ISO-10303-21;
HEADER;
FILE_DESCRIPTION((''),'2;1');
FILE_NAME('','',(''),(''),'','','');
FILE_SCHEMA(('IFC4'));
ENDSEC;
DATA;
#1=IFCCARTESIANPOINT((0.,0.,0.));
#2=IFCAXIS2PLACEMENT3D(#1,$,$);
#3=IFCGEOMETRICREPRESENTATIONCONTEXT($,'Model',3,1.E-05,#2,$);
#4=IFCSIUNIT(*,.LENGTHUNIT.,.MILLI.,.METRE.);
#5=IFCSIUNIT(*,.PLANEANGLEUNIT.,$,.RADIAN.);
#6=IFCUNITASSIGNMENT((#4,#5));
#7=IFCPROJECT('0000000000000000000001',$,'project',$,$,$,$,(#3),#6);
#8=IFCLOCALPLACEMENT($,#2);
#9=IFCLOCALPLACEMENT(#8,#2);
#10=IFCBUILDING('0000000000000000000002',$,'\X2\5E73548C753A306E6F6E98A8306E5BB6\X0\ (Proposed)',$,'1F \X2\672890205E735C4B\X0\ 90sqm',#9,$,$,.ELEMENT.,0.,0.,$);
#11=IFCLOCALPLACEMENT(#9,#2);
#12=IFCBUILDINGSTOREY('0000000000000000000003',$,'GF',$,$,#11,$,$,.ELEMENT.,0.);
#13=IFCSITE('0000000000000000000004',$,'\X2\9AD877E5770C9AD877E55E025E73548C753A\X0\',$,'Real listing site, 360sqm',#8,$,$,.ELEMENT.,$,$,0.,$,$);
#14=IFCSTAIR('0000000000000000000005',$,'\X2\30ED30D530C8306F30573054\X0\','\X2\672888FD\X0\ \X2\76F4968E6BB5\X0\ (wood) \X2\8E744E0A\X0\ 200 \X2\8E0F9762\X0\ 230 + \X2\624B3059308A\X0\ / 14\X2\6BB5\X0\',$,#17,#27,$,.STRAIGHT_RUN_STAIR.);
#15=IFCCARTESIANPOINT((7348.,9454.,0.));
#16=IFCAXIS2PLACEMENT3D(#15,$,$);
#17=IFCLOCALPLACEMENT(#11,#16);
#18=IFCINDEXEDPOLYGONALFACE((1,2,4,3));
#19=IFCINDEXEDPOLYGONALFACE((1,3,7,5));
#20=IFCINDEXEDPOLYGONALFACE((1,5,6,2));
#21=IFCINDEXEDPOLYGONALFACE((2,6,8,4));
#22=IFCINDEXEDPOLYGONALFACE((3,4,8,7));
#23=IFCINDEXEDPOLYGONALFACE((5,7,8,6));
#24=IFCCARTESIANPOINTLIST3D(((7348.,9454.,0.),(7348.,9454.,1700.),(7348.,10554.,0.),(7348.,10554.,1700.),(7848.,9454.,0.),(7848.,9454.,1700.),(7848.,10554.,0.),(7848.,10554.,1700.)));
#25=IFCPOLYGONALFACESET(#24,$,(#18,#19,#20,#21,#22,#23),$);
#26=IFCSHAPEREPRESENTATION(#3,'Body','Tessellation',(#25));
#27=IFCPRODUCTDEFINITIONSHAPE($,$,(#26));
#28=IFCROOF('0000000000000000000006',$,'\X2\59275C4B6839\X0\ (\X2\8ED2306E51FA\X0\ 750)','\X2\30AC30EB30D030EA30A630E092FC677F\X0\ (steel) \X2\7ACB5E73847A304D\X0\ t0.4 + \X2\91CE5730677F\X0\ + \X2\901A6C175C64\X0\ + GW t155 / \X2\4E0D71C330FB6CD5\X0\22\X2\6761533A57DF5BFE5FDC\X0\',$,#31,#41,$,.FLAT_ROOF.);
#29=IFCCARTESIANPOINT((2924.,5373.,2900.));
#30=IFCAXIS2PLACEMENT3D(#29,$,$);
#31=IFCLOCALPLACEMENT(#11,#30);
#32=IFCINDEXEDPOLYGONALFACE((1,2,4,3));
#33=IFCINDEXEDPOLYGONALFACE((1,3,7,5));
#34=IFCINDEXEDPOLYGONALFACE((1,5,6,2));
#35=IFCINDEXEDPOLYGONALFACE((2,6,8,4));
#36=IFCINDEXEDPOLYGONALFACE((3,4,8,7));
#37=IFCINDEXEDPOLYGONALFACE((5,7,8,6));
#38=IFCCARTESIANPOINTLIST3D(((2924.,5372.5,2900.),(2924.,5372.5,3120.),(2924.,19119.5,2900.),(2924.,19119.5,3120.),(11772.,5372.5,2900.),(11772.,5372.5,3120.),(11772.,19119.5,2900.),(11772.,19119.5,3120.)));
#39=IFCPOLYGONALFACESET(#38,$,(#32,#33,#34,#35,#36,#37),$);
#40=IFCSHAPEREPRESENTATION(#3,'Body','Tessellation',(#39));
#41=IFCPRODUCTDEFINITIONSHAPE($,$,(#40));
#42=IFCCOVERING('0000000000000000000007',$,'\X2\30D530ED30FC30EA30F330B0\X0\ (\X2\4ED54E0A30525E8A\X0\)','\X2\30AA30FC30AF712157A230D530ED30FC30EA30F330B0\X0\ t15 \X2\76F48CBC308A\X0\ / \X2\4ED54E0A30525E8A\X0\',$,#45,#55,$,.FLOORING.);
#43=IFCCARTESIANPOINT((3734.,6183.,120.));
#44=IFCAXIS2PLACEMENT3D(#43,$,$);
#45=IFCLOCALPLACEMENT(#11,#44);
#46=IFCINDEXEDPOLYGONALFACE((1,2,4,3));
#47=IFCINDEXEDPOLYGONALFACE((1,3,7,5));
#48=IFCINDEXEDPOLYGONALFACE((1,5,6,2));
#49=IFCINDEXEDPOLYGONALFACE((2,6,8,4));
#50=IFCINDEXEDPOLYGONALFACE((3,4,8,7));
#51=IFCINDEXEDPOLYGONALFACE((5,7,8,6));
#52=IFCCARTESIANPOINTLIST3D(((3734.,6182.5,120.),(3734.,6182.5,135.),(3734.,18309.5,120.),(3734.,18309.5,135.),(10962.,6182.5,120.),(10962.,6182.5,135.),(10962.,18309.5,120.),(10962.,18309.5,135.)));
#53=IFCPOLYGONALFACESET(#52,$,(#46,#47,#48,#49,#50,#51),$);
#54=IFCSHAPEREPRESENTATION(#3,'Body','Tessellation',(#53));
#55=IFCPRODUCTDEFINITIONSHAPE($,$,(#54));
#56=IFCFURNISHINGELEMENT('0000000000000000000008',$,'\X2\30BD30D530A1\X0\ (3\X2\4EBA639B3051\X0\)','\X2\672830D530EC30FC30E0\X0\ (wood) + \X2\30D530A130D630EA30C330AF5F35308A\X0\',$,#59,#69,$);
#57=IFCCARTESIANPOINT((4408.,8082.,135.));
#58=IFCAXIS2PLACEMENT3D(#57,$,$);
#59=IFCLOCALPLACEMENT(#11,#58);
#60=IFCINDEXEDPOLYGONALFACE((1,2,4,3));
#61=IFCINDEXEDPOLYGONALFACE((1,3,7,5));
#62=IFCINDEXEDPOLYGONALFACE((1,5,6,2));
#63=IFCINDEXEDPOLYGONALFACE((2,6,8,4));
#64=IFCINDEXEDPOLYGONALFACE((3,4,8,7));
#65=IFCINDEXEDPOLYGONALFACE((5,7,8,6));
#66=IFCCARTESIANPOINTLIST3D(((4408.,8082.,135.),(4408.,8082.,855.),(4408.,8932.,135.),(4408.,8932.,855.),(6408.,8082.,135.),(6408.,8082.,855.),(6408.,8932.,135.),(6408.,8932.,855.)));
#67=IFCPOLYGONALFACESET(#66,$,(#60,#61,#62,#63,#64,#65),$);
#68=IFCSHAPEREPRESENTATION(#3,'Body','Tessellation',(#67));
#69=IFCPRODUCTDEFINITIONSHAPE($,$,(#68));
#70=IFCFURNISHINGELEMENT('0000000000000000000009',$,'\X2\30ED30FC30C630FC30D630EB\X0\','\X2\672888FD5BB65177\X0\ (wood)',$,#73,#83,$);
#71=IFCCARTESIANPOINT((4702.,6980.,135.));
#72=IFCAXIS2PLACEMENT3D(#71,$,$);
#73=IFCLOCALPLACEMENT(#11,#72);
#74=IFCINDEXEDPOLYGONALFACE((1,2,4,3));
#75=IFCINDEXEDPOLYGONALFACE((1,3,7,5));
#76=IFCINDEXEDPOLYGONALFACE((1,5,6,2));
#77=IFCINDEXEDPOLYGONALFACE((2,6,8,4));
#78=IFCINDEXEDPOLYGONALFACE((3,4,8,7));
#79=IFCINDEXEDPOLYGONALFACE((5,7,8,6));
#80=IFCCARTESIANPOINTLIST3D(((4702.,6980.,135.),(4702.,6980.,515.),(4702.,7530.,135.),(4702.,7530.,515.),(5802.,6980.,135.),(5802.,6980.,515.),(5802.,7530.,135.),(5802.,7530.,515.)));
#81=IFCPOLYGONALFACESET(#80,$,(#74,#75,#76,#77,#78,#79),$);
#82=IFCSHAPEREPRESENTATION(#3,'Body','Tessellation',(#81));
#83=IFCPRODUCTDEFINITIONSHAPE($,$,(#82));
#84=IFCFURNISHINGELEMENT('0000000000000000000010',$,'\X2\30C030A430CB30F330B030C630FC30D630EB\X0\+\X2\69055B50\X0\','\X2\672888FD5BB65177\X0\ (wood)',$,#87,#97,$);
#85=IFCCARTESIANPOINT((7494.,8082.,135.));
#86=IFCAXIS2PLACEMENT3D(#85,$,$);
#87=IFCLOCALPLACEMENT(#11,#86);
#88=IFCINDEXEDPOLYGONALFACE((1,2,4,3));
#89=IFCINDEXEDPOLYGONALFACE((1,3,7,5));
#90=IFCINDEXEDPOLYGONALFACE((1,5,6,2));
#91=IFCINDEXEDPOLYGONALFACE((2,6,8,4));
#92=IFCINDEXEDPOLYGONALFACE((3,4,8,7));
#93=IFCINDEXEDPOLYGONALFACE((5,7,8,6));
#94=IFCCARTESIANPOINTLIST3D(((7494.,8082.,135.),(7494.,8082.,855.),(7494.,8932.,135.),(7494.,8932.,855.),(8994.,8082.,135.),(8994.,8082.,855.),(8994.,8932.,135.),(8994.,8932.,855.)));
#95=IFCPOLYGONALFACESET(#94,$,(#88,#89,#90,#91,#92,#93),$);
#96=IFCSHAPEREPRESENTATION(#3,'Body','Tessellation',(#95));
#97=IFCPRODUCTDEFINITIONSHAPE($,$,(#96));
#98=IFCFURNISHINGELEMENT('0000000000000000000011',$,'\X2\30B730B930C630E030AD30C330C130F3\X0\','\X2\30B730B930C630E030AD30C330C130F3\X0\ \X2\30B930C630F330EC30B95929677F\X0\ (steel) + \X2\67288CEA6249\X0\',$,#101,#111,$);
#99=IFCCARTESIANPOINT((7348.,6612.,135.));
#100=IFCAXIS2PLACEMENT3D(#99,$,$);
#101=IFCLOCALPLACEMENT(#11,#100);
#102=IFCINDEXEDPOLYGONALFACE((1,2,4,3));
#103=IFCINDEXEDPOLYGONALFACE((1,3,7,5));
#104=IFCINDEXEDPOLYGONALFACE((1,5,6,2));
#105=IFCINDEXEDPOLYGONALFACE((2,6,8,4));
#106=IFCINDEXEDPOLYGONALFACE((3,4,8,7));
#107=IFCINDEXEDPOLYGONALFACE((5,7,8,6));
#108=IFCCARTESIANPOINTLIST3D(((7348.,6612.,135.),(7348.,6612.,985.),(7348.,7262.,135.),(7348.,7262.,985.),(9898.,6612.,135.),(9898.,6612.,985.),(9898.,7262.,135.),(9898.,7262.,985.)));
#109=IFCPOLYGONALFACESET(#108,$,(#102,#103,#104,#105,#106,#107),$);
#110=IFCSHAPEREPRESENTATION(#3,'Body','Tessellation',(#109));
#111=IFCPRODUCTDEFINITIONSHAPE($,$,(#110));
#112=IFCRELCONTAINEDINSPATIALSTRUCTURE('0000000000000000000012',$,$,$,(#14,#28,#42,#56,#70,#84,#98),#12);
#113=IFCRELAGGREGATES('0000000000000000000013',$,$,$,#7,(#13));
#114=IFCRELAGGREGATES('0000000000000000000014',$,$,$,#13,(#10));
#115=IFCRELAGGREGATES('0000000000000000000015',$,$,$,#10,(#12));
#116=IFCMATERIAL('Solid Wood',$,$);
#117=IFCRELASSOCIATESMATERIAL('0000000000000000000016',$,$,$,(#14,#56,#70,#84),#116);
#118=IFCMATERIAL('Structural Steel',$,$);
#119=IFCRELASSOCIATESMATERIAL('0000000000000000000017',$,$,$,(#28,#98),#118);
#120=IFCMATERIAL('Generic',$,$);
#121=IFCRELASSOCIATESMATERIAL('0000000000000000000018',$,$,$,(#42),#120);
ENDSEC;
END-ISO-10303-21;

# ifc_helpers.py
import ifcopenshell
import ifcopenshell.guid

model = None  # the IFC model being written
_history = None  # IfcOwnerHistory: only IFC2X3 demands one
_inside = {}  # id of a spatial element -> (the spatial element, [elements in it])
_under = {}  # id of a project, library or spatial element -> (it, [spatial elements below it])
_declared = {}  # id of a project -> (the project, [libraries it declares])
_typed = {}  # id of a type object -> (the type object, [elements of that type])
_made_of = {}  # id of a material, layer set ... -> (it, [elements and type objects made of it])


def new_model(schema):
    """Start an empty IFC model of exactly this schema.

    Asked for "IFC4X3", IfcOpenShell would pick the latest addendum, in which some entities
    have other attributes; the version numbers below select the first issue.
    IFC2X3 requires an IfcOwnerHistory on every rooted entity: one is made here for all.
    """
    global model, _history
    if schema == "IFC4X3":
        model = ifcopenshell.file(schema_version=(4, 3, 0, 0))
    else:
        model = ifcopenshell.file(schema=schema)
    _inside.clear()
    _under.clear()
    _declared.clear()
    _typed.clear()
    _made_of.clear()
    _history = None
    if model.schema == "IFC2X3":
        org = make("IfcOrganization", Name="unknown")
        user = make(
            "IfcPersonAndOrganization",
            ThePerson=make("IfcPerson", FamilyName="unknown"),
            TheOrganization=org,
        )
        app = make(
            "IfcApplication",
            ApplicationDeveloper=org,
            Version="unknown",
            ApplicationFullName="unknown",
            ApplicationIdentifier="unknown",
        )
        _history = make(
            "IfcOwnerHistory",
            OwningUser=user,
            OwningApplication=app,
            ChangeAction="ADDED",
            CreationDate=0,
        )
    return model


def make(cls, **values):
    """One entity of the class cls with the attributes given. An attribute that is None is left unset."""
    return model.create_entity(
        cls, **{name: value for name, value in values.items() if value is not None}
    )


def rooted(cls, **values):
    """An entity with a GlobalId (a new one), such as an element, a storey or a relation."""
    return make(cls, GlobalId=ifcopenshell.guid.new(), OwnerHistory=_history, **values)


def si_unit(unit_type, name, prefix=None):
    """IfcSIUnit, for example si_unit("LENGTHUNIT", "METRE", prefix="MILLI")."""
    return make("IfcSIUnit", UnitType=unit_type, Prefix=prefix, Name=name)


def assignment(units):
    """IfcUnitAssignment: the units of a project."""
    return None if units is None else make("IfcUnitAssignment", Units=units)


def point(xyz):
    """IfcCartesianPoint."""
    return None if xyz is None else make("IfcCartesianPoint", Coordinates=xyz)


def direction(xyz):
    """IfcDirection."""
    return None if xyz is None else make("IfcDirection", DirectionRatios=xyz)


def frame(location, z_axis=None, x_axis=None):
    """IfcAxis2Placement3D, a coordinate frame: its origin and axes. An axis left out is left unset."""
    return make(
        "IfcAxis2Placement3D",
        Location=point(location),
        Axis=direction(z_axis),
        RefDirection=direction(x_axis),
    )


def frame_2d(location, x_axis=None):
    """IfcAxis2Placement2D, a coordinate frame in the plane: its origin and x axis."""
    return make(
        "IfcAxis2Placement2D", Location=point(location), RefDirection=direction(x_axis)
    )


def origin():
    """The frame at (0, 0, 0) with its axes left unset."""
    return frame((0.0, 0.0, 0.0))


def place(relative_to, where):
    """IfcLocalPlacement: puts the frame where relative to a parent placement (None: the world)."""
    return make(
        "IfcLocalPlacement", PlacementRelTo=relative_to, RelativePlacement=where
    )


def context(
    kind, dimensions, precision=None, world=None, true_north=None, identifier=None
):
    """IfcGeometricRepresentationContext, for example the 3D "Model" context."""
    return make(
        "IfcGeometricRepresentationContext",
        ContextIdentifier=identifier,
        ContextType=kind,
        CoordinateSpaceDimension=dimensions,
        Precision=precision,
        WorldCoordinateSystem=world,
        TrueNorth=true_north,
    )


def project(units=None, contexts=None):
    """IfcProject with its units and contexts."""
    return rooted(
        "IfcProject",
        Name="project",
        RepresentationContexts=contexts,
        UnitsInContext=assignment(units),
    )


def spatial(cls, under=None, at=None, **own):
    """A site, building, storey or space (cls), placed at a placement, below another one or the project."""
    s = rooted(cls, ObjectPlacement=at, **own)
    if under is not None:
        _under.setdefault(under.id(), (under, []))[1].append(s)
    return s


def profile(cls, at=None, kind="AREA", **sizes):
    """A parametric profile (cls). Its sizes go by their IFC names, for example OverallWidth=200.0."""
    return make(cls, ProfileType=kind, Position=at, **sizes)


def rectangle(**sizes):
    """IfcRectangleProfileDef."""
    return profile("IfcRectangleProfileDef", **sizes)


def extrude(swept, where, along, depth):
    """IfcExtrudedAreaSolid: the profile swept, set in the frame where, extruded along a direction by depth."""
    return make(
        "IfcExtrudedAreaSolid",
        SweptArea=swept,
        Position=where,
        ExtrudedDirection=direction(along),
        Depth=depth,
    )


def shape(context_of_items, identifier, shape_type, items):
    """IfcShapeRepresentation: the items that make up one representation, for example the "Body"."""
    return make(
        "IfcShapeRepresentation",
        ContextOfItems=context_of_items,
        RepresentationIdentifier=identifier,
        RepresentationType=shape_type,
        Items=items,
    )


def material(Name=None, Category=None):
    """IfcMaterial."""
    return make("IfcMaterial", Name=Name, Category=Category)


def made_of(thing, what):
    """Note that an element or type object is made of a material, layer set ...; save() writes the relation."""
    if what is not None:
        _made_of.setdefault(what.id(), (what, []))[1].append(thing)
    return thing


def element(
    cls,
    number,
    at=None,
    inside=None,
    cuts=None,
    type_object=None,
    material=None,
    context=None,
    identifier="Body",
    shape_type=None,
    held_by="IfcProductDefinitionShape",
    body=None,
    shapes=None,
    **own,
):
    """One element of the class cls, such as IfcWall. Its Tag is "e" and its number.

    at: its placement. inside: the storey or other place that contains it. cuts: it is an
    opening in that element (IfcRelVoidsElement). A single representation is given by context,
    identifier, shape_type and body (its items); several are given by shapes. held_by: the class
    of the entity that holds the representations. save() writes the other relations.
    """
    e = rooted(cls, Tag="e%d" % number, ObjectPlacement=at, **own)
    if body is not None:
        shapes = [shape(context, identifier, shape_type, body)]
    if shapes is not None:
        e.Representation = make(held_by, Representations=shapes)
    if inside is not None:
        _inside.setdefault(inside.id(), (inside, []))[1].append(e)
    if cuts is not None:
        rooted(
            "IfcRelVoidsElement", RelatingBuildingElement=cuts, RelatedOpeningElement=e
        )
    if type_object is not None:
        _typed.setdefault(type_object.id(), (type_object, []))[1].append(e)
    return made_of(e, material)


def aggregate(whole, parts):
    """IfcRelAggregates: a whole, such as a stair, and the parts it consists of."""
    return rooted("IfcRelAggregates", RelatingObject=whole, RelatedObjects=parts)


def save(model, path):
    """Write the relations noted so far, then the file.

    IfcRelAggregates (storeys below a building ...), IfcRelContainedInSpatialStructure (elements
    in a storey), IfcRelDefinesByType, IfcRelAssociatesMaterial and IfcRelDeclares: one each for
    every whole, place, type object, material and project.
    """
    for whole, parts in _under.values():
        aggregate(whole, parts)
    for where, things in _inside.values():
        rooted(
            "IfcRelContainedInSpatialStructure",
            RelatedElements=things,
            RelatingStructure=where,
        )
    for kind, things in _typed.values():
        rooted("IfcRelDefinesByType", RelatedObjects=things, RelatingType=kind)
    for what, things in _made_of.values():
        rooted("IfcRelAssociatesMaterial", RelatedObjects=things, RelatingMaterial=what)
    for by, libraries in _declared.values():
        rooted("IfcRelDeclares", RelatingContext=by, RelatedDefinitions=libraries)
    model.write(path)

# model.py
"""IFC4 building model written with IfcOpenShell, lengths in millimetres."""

from ifc_helpers import new_model, si_unit, frame, frame_2d, origin, place, context, project, spatial, rectangle, extrude, material, element, save


model = new_model("IFC4")

# Units and contexts
model_context = context("Model", 3, precision=1e-05, world=origin())
ifc_project = project(units=[si_unit("LENGTHUNIT", "METRE", prefix="MILLI"), si_unit("PLANEANGLEUNIT", "RADIAN")], contexts=[model_context])

# Site, building, storey
site_placement = place(None, origin())
site = spatial("IfcSite", under=ifc_project, at=site_placement, Name="高知県高知市平和町", ObjectType="Real listing site, 360sqm", CompositionType="ELEMENT", RefElevation=0.0)
building_placement = place(site_placement, origin())
building = spatial("IfcBuilding", under=site, at=building_placement, Name="平和町の潮風の家 (Proposed)", ObjectType="1F 木造平屋 90sqm", CompositionType="ELEMENT", ElevationOfRefHeight=0.0, ElevationOfTerrain=0.0)
storey_placement = place(building_placement, origin())
storey = spatial("IfcBuildingStorey", under=building, at=storey_placement, Name="GF", CompositionType="ELEMENT", Elevation=0.0)

# Shared definitions
ifc_material_1 = material(Name="Solid Wood")

# Stair
stair_placement = place(storey_placement, frame((7348.0, 9454.0, 0.0)))
element("IfcStair", 1, at=stair_placement, inside=storey, material=ifc_material_1, Name="ロフトはしご", Description="木製 直階段 (wood) 蹴上 200 踏面 230 + 手すり / 14段", PredefinedType="STRAIGHT_RUN_STAIR", context=model_context, shape_type="SweptSolid", body=[
    extrude(rectangle(XDim=500.0, YDim=1100.0, at=frame_2d((250.0, 550.0))), frame((7348.0, 9454.0, 0.0)), (0.0, 0.0, 1.0), 1700.0),
])

# Roof
ifc_material_2 = material(Name="Structural Steel")
roof_placement = place(storey_placement, frame((2924.0, 5373.0, 2900.0)))
element("IfcRoof", 2, at=roof_placement, inside=storey, material=ifc_material_2, Name="大屋根 (軒の出 750)", Description="ガルバリウム鋼板 (steel) 立平葺き t0.4 + 野地板 + 通気層 + GW t155 / 不燃・法22条区域対応", PredefinedType="FLAT_ROOF", context=model_context, shape_type="SweptSolid", body=[
    extrude(rectangle(XDim=8848.0, YDim=13747.0, at=frame_2d((4424.0, 6873.0))), frame((2924.0, 5373.0, 2900.0)), (0.0, 0.0, 1.0), 220.0),
])

# Covering
ifc_material_3 = material(Name="Generic")
covering_placement = place(storey_placement, frame((3734.0, 6183.0, 120.0)))
element("IfcCovering", 3, at=covering_placement, inside=storey, material=ifc_material_3, Name="フローリング (仕上げ床)", Description="オーク無垢フローリング t15 直貼り / 仕上げ床", PredefinedType="FLOORING", context=model_context, shape_type="SweptSolid", body=[
    extrude(rectangle(XDim=7228.0, YDim=12127.0, at=frame_2d((3614.0, 6063.0))), frame((3734.0, 6183.0, 120.0)), (0.0, 0.0, 1.0), 15.0),
])

# Furnishing elements
furnishing_1_placement = place(storey_placement, frame((4408.0, 8082.0, 135.0)))
element("IfcFurnishingElement", 4, at=furnishing_1_placement, inside=storey, material=ifc_material_1, Name="ソファ (3人掛け)", Description="木フレーム (wood) + ファブリック張り", context=model_context, shape_type="SweptSolid", body=[
    extrude(rectangle(XDim=2000.0, YDim=850.0, at=frame_2d((1000.0, 425.0))), frame((4408.0, 8082.0, 135.0)), (0.0, 0.0, 1.0), 720.0),
])
furnishing_2_placement = place(storey_placement, frame((4702.0, 6980.0, 135.0)))
element("IfcFurnishingElement", 5, at=furnishing_2_placement, inside=storey, material=ifc_material_1, Name="ローテーブル", Description="木製家具 (wood)", context=model_context, shape_type="SweptSolid", body=[
    extrude(rectangle(XDim=1100.0, YDim=550.0, at=frame_2d((550.0, 275.0))), frame((4702.0, 6980.0, 135.0)), (0.0, 0.0, 1.0), 380.0),
])
furnishing_3_placement = place(storey_placement, frame((7494.0, 8082.0, 135.0)))
element("IfcFurnishingElement", 6, at=furnishing_3_placement, inside=storey, material=ifc_material_1, Name="ダイニングテーブル+椅子", Description="木製家具 (wood)", context=model_context, shape_type="SweptSolid", body=[
    extrude(rectangle(XDim=1500.0, YDim=850.0, at=frame_2d((750.0, 425.0))), frame((7494.0, 8082.0, 135.0)), (0.0, 0.0, 1.0), 720.0),
])
furnishing_4_placement = place(storey_placement, frame((7348.0, 6612.0, 135.0)))
element("IfcFurnishingElement", 7, at=furnishing_4_placement, inside=storey, material=ifc_material_2, Name="システムキッチン", Description="システムキッチン ステンレス天板 (steel) + 木質扉", context=model_context, shape_type="SweptSolid", body=[
    extrude(rectangle(XDim=2550.0, YDim=650.0, at=frame_2d((1275.0, 325.0))), frame((7348.0, 6612.0, 135.0)), (0.0, 0.0, 1.0), 850.0),
])

save(model, "model.ifc")
